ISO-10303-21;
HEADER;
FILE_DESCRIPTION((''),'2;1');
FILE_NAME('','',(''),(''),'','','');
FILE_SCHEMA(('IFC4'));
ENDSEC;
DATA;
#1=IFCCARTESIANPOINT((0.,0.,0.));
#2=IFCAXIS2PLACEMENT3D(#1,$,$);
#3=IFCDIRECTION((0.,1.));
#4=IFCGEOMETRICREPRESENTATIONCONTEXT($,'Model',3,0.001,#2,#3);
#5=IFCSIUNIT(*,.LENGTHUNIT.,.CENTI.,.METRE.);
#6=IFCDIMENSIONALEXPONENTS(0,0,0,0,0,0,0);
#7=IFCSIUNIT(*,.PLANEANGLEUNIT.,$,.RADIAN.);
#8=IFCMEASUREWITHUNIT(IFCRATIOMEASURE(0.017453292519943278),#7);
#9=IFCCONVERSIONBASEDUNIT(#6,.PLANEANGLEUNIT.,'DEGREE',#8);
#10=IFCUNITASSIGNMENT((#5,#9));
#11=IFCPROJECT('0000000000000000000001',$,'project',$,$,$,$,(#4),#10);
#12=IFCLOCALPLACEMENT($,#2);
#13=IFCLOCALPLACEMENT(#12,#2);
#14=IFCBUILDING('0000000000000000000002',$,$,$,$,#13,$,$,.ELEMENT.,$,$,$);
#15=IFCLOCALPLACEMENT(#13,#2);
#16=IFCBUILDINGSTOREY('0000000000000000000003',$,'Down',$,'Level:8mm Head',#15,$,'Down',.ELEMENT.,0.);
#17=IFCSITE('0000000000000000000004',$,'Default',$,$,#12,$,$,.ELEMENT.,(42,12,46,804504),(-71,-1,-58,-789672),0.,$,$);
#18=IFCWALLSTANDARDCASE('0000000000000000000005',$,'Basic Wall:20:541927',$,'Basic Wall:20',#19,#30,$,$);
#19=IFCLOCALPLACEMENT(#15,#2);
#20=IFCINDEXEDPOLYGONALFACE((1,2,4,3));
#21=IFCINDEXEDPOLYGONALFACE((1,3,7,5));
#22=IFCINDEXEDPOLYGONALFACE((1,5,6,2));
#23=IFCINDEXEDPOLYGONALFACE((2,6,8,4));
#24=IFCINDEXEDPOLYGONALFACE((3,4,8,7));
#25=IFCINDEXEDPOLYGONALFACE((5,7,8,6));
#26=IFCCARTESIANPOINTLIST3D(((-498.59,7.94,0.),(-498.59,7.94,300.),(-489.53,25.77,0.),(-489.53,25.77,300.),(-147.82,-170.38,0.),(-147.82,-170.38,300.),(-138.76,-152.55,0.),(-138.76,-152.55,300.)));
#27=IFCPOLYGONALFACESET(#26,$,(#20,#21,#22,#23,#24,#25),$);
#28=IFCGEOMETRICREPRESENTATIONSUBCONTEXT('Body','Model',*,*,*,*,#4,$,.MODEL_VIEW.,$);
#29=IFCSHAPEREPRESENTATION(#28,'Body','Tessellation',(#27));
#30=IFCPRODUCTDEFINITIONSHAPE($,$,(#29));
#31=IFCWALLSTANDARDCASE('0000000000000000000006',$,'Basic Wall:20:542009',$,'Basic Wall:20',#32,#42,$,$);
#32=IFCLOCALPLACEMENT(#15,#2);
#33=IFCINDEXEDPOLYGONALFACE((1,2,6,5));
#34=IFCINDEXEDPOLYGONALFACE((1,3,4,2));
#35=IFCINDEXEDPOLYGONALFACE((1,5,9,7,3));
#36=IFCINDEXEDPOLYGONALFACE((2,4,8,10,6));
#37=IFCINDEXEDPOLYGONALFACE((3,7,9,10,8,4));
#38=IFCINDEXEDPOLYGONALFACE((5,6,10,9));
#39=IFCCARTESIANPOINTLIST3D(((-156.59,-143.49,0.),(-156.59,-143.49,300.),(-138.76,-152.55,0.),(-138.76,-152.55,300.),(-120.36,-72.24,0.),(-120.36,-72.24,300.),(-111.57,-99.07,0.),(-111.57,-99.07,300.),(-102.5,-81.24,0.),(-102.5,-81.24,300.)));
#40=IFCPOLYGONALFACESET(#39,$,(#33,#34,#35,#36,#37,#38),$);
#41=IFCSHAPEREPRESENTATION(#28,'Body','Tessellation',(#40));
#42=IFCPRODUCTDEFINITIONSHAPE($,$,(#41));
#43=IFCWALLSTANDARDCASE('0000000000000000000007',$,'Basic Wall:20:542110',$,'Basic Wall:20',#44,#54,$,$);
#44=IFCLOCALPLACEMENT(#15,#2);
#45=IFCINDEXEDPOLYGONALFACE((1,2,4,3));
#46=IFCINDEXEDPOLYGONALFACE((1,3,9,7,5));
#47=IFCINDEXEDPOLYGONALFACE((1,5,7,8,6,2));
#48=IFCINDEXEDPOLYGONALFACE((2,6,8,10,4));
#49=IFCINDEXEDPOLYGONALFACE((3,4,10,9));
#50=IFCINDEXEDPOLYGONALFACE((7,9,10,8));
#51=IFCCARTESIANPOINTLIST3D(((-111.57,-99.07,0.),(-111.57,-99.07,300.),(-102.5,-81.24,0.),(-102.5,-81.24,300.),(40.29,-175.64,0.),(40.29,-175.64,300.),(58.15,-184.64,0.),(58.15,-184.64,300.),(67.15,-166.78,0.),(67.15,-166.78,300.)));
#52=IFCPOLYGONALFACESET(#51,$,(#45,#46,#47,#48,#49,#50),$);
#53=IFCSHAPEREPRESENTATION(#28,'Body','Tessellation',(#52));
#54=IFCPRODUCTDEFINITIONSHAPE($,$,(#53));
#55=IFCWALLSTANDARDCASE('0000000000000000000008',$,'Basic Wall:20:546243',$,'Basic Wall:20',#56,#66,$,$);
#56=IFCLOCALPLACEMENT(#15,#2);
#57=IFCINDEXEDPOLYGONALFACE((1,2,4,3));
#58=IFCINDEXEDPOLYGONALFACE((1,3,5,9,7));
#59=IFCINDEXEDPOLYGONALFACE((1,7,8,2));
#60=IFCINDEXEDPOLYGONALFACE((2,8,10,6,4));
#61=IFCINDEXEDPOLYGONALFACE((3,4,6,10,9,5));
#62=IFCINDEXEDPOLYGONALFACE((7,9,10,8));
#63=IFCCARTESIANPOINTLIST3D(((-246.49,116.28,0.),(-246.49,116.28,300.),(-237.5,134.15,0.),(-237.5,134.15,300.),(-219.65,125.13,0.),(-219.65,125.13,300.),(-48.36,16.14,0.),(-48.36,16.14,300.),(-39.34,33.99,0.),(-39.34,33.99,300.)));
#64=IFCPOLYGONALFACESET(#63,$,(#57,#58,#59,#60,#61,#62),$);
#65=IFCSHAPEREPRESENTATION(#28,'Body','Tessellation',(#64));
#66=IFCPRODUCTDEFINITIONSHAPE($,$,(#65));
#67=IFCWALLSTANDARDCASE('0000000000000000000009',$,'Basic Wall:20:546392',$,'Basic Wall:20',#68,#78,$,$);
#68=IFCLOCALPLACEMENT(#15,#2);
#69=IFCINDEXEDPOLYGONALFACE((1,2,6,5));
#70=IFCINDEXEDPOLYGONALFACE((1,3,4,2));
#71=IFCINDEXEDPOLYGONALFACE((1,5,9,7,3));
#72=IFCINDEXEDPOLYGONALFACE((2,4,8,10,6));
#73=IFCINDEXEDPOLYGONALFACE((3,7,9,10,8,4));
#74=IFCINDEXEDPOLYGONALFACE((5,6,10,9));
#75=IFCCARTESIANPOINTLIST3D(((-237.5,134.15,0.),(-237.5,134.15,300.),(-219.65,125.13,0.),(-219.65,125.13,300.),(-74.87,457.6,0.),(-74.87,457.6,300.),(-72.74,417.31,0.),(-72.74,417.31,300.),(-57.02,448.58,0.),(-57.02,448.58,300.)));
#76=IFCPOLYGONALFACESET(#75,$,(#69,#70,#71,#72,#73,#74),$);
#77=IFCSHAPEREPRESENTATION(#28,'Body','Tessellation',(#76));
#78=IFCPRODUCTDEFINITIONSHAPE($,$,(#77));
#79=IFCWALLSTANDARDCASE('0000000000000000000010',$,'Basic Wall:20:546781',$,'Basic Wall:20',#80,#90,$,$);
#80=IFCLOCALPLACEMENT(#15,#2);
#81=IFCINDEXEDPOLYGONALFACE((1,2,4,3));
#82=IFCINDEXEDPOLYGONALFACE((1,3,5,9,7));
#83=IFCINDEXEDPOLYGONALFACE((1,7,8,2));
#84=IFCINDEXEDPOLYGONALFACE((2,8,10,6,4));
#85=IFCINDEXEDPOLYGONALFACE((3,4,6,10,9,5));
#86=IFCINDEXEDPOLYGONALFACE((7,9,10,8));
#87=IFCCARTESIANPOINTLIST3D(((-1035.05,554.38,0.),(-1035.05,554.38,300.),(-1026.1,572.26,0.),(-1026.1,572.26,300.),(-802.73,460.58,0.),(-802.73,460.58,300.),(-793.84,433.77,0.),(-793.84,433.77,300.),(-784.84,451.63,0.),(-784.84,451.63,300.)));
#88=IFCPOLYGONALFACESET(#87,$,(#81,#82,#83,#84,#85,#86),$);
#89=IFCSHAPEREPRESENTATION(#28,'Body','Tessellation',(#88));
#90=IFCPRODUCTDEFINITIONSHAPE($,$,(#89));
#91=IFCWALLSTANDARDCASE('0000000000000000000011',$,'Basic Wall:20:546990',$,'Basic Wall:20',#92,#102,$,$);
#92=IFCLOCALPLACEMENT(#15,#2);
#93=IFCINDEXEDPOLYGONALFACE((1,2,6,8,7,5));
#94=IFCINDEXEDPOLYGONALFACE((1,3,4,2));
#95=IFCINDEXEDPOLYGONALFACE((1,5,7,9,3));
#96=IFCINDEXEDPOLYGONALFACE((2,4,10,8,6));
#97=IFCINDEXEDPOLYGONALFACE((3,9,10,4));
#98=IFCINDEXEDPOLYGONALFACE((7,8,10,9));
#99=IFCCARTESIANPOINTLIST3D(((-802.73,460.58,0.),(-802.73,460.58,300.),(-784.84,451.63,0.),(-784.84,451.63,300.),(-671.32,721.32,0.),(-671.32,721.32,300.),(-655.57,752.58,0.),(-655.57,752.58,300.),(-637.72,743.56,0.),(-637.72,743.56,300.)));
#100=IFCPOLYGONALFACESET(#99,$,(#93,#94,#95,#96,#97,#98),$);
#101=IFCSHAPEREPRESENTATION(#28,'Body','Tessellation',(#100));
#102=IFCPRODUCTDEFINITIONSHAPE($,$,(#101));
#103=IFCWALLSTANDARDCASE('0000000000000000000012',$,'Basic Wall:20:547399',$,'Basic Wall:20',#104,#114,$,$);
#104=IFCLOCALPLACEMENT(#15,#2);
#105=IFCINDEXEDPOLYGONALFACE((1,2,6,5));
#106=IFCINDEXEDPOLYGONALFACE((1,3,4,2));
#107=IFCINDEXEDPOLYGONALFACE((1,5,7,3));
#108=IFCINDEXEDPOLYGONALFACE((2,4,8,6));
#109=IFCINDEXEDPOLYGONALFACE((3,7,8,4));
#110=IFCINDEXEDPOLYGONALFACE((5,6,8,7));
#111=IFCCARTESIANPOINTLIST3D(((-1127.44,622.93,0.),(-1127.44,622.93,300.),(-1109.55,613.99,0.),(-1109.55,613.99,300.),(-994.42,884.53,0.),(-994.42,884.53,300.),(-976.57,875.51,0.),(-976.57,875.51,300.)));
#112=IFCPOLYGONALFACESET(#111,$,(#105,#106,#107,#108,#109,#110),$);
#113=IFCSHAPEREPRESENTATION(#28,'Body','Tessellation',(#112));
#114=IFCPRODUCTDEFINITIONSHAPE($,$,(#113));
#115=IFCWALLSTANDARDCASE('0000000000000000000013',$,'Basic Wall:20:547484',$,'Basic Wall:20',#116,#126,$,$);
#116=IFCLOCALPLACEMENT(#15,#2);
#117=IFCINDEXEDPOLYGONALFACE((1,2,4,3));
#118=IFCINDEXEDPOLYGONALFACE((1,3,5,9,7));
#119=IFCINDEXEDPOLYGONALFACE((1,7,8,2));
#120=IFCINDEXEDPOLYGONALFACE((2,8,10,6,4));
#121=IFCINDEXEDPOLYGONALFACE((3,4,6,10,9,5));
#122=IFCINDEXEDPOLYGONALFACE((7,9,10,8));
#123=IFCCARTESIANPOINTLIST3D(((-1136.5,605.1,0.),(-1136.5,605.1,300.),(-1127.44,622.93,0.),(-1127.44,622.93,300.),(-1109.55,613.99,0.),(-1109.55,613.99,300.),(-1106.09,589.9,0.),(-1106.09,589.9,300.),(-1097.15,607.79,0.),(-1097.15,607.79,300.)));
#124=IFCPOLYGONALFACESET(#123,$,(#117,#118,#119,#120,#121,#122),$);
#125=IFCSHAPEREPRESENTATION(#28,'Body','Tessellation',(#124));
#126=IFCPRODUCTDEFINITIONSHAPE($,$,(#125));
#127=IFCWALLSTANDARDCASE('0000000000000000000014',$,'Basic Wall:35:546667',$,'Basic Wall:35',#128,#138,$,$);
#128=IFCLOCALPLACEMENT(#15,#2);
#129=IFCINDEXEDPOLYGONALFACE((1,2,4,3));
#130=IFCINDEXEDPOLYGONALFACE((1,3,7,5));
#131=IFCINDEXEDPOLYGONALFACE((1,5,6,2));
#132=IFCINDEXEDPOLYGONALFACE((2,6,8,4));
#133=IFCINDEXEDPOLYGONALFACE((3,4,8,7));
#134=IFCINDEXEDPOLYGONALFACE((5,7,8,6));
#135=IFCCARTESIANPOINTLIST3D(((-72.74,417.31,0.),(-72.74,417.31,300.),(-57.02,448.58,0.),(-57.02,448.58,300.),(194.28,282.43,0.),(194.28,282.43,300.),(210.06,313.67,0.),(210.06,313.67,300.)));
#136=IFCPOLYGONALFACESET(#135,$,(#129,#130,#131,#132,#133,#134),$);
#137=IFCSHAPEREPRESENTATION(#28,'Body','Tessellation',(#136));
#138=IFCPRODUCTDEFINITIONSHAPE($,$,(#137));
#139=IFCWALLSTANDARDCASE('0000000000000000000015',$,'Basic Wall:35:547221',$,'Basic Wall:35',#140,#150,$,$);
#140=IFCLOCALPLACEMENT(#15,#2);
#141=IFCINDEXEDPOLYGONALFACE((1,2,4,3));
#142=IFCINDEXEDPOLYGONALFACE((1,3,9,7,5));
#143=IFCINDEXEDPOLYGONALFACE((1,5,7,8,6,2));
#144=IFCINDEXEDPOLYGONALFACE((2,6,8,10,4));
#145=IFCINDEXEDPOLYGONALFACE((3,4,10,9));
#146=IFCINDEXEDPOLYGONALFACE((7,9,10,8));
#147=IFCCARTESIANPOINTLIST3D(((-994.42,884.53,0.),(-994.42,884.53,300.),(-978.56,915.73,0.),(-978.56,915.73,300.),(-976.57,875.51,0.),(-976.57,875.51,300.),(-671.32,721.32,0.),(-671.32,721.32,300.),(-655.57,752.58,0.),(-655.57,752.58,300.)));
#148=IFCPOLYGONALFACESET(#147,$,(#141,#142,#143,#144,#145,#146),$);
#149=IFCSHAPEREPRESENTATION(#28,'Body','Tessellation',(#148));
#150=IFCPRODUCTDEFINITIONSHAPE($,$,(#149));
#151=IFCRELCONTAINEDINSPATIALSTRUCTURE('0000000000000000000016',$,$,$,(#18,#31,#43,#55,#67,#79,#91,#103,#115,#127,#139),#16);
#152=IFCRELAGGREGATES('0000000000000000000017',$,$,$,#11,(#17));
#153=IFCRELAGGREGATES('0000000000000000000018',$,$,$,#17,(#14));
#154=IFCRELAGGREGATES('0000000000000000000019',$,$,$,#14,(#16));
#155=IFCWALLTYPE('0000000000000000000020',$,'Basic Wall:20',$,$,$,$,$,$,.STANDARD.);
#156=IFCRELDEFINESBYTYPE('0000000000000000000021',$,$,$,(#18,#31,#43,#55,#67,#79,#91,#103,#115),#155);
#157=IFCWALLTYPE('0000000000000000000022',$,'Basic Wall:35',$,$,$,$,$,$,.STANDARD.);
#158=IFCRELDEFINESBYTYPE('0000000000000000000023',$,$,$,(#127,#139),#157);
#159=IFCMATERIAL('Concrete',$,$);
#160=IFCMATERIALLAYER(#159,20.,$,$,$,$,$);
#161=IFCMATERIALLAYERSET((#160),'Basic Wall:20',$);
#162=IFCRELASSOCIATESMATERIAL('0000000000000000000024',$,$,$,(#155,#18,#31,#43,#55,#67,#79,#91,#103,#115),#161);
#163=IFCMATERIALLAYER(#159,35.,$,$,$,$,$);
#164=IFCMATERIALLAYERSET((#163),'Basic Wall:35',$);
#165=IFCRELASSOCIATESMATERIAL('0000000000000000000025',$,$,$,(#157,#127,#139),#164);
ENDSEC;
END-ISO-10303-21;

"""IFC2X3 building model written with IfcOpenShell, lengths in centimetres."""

from ifc_helpers import new_model, entity, si_unit, converted_unit, direction, frame, frame_2d, origin, place, context, subcontext, project, spatial, polyline, rectangle, outline, extrude, material, layer, layer_set, layer_usage, type_object, element, save


model = new_model("IFC2X3")

# Units and contexts
model_context = context("Model", 3, precision=0.001, world=origin(), true_north=direction((0.0, 1.0)))
body_context = subcontext(model_context, "Body", "Model", "MODEL_VIEW")
ifc_project = project(units=[si_unit("LENGTHUNIT", "METRE", prefix="CENTI"), converted_unit("PLANEANGLEUNIT", "DEGREE", entity("IfcRatioMeasure", 0.017453292519943278), si_unit("PLANEANGLEUNIT", "RADIAN"), dimensions=[0, 0, 0, 0, 0, 0, 0])], contexts=[model_context])

# Site, building, storey
site_placement = place(None, origin())
site = spatial("IfcSite", under=ifc_project, at=site_placement, Name="Default", CompositionType="ELEMENT", RefLatitude=(42, 12, 46, 804504), RefLongitude=(-71, -1, -58, -789672), RefElevation=0.0)
building_placement = place(site_placement, origin())
building = spatial("IfcBuilding", under=site, at=building_placement, CompositionType="ELEMENT")
storey_placement = place(building_placement, origin())
storey = spatial("IfcBuildingStorey", under=building, at=storey_placement, Name="Down", ObjectType="Level:8mm Head", LongName="Down", CompositionType="ELEMENT", Elevation=0.0)

# Shared definitions
ifc_material = material(Name="Concrete")

# Walls
ifc_layer_1 = layer(ifc_material, 20.0)
ifc_layer_set_1 = layer_set([ifc_layer_1], Name="Basic Wall:20")
wall_type_1 = type_object("IfcWallType", Name="Basic Wall:20", PredefinedType="STANDARD", material=ifc_layer_set_1)
ifc_layer_usage_1 = layer_usage(ifc_layer_set_1, "AXIS2", "NEGATIVE", 10.0)
wall_1_placement = place(storey_placement, frame((-494.06, 16.86, 0.0), z_axis=(0.0, 0.0, 1.0), x_axis=(0.891419, -0.45318, 0.0)))
element("IfcWallStandardCase", 1, at=wall_1_placement, inside=storey, type_object=wall_type_1, material=ifc_layer_usage_1, Name="Basic Wall:20:541927", ObjectType="Basic Wall:20", context=body_context, shape_type="SweptSolid", body=[
    extrude(rectangle(XDim=393.5, YDim=20.0, at=frame_2d((196.75, 0.0), x_axis=(-1.0, 0.0))), origin(), (0.0, 0.0, 1.0), 300.0),
])
ifc_layer_usage_2 = layer_usage(ifc_layer_set_1, "AXIS2", "POSITIVE", -10.0)
wall_2_placement = place(storey_placement, frame((-147.67, -148.02, 0.0), z_axis=(0.0, 0.0, 1.0), x_axis=(0.45318, 0.891419, 0.0)))
element("IfcWallStandardCase", 2, at=wall_2_placement, inside=storey, type_object=wall_type_1, material=ifc_layer_usage_2, Name="Basic Wall:20:542009", ObjectType="Basic Wall:20", context=body_context, shape_type="SweptSolid", body=[
    extrude(outline(polyline([(80.0, -10.0), (79.93, 10.0), (0.0, 10.0), (0.0, -10.0), (60.0, -10.0), (80.0, -10.0)])), origin(), (0.0, 0.0, 1.0), 300.0),
])
ifc_layer_usage_3 = layer_usage(ifc_layer_set_1, "AXIS2", "NEGATIVE", 10.0)
wall_3_placement = place(storey_placement, frame((-107.06, -90.14, 0.0), z_axis=(0.0, 0.0, 1.0), x_axis=(0.892913, -0.450229, 0.0)))
element("IfcWallStandardCase", 3, at=wall_3_placement, inside=storey, type_object=wall_type_1, material=ifc_layer_usage_3, Name="Basic Wall:20:542110", ObjectType="Basic Wall:20", context=body_context, shape_type="SweptSolid", body=[
    extrude(outline(polyline([(190.07, -10.0), (190.07, 10.0), (0.07, 10.0), (0.0, -10.0), (170.07, -10.0), (190.07, -10.0)])), origin(), (0.0, 0.0, 1.0), 300.0),
])
ifc_layer_usage_4 = layer_usage(ifc_layer_set_1, "AXIS2", "NEGATIVE", 10.0)
wall_4_placement = place(storey_placement, frame((-43.85, 25.07, 0.0), z_axis=(0.0, 0.0, 1.0), x_axis=(-0.892482, 0.451084, 0.0)))
element("IfcWallStandardCase", 4, at=wall_4_placement, inside=storey, type_object=wall_type_1, material=ifc_layer_usage_4, Name="Basic Wall:20:546243", ObjectType="Basic Wall:20", context=body_context, shape_type="SweptSolid", body=[
    extrude(outline(polyline([(222.04, -10.0), (222.0, 10.0), (0.0, 10.0), (0.0, -10.0), (202.04, -10.0), (222.04, -10.0)])), origin(), (0.0, 0.0, 1.0), 300.0),
])
ifc_layer_usage_5 = layer_usage(ifc_layer_set_1, "AXIS2", "NEGATIVE", 10.0)
wall_5_placement = place(storey_placement, frame((-228.59, 129.62, 0.0), z_axis=(0.0, 0.0, 1.0), x_axis=(0.449231, 0.893415, 0.0)))
element("IfcWallStandardCase", 5, at=wall_5_placement, inside=storey, type_object=wall_type_1, material=ifc_layer_usage_5, Name="Basic Wall:20:546392", ObjectType="Basic Wall:20", context=body_context, shape_type="SweptSolid", body=[
    extrude(outline(polyline([(362.04, -10.0), (362.07, 10.0), (0.04, 10.0), (0.0, -10.0), (327.04, -10.0), (362.04, -10.0)])), origin(), (0.0, 0.0, 1.0), 300.0),
])
ifc_layer_usage_6 = layer_usage(ifc_layer_set_1, "AXIS2", "POSITIVE", -10.0)
wall_6_placement = place(storey_placement, frame((-1030.58, 563.32, 0.0), z_axis=(0.0, 0.0, 1.0), x_axis=(0.894427, -0.447214, 0.0)))
element("IfcWallStandardCase", 6, at=wall_6_placement, inside=storey, type_object=wall_type_1, material=ifc_layer_usage_6, Name="Basic Wall:20:546781", ObjectType="Basic Wall:20", context=body_context, shape_type="SweptSolid", body=[
    extrude(outline(polyline([(269.68, -10.0), (269.74, 10.0), (249.74, 10.0), (0.0, 10.0), (0.0, -10.0), (269.68, -10.0)])), origin(), (0.0, 0.0, 1.0), 300.0),
])
ifc_layer_usage_7 = layer_usage(ifc_layer_set_1, "AXIS2", "POSITIVE", -10.0)
wall_7_placement = place(storey_placement, frame((-793.8, 456.08, 0.0), z_axis=(0.0, 0.0, 1.0), x_axis=(0.450035, 0.893011, 0.0)))
element("IfcWallStandardCase", 7, at=wall_7_placement, inside=storey, type_object=wall_type_1, material=ifc_layer_usage_7, Name="Basic Wall:20:546990", ObjectType="Basic Wall:20", context=body_context, shape_type="SweptSolid", body=[
    extrude(outline(polyline([(326.97, -10.0), (326.98, 10.0), (291.98, 10.0), (0.0, 10.0), (0.06, -10.0), (326.97, -10.0)])), origin(), (0.0, 0.0, 1.0), 300.0),
])
ifc_layer_usage_8 = layer_usage(ifc_layer_set_1, "AXIS2", "POSITIVE", -10.0)
wall_8_placement = place(storey_placement, frame((-985.49, 880.04, 0.0), z_axis=(0.0, 0.0, 1.0), x_axis=(-0.453247, -0.891385, 0.0)))
element("IfcWallStandardCase", 8, at=wall_8_placement, inside=storey, type_object=wall_type_1, material=ifc_layer_usage_8, Name="Basic Wall:20:547399", ObjectType="Basic Wall:20", context=body_context, shape_type="SweptSolid", body=[
    extrude(outline(polyline([(293.53, -10.0), (293.39, 10.0), (0.0, 10.0), (0.05, -10.0), (293.53, -10.0)])), origin(), (0.0, 0.0, 1.0), 300.0),
])
ifc_layer_usage_9 = layer_usage(ifc_layer_set_1, "AXIS2", "POSITIVE", -10.0)
wall_9_placement = place(storey_placement, frame((-1132.03, 614.05, 0.0), z_axis=(0.0, 0.0, 1.0), x_axis=(0.894427, -0.447214, 0.0)))
element("IfcWallStandardCase", 9, at=wall_9_placement, inside=storey, type_object=wall_type_1, material=ifc_layer_usage_9, Name="Basic Wall:20:547484", ObjectType="Basic Wall:20", context=body_context, shape_type="SweptSolid", body=[
    extrude(outline(polyline([(34.0, -10.0), (34.0, 10.0), (20.14, 10.0), (0.14, 10.0), (0.0, -10.0), (34.0, -10.0)])), origin(), (0.0, 0.0, 1.0), 300.0),
])
ifc_layer_2 = layer(ifc_material, 35.0)
ifc_layer_set_2 = layer_set([ifc_layer_2], Name="Basic Wall:35")
ifc_layer_usage_10 = layer_usage(ifc_layer_set_2, "AXIS2", "NEGATIVE", 17.5)
wall_type_2 = type_object("IfcWallType", Name="Basic Wall:35", PredefinedType="STANDARD", material=ifc_layer_set_2)
wall_10_placement = place(storey_placement, frame((-64.91, 432.96, 0.0), z_axis=(0.0, 0.0, 1.0), x_axis=(0.892587, -0.450875, 0.0)))
element("IfcWallStandardCase", 10, at=wall_10_placement, inside=storey, type_object=wall_type_2, material=ifc_layer_usage_10, Name="Basic Wall:35:546667", ObjectType="Basic Wall:35", context=body_context, shape_type="SweptSolid", body=[
    extrude(outline(polyline([(299.21, -17.5), (299.22, 17.5), (0.0, 17.5), (0.06, -17.5), (299.21, -17.5)])), origin(), (0.0, 0.0, 1.0), 300.0),
])
ifc_layer_usage_11 = layer_usage(ifc_layer_set_2, "AXIS2", "POSITIVE", -17.5)
wall_11_placement = place(storey_placement, frame((-663.43, 736.94, 0.0), z_axis=(0.0, 0.0, 1.0), x_axis=(-0.892587, 0.450875, 0.0)))
element("IfcWallStandardCase", 11, at=wall_11_placement, inside=storey, type_object=wall_type_2, material=ifc_layer_usage_11, Name="Basic Wall:35:547221", ObjectType="Basic Wall:35", context=body_context, shape_type="SweptSolid", body=[
    extrude(outline(polyline([(361.89, -17.5), (361.98, 17.5), (341.98, 17.5), (0.0, 17.5), (0.03, -17.5), (361.89, -17.5)])), origin(), (0.0, 0.0, 1.0), 300.0),
])

save(model, "model.ifc")
